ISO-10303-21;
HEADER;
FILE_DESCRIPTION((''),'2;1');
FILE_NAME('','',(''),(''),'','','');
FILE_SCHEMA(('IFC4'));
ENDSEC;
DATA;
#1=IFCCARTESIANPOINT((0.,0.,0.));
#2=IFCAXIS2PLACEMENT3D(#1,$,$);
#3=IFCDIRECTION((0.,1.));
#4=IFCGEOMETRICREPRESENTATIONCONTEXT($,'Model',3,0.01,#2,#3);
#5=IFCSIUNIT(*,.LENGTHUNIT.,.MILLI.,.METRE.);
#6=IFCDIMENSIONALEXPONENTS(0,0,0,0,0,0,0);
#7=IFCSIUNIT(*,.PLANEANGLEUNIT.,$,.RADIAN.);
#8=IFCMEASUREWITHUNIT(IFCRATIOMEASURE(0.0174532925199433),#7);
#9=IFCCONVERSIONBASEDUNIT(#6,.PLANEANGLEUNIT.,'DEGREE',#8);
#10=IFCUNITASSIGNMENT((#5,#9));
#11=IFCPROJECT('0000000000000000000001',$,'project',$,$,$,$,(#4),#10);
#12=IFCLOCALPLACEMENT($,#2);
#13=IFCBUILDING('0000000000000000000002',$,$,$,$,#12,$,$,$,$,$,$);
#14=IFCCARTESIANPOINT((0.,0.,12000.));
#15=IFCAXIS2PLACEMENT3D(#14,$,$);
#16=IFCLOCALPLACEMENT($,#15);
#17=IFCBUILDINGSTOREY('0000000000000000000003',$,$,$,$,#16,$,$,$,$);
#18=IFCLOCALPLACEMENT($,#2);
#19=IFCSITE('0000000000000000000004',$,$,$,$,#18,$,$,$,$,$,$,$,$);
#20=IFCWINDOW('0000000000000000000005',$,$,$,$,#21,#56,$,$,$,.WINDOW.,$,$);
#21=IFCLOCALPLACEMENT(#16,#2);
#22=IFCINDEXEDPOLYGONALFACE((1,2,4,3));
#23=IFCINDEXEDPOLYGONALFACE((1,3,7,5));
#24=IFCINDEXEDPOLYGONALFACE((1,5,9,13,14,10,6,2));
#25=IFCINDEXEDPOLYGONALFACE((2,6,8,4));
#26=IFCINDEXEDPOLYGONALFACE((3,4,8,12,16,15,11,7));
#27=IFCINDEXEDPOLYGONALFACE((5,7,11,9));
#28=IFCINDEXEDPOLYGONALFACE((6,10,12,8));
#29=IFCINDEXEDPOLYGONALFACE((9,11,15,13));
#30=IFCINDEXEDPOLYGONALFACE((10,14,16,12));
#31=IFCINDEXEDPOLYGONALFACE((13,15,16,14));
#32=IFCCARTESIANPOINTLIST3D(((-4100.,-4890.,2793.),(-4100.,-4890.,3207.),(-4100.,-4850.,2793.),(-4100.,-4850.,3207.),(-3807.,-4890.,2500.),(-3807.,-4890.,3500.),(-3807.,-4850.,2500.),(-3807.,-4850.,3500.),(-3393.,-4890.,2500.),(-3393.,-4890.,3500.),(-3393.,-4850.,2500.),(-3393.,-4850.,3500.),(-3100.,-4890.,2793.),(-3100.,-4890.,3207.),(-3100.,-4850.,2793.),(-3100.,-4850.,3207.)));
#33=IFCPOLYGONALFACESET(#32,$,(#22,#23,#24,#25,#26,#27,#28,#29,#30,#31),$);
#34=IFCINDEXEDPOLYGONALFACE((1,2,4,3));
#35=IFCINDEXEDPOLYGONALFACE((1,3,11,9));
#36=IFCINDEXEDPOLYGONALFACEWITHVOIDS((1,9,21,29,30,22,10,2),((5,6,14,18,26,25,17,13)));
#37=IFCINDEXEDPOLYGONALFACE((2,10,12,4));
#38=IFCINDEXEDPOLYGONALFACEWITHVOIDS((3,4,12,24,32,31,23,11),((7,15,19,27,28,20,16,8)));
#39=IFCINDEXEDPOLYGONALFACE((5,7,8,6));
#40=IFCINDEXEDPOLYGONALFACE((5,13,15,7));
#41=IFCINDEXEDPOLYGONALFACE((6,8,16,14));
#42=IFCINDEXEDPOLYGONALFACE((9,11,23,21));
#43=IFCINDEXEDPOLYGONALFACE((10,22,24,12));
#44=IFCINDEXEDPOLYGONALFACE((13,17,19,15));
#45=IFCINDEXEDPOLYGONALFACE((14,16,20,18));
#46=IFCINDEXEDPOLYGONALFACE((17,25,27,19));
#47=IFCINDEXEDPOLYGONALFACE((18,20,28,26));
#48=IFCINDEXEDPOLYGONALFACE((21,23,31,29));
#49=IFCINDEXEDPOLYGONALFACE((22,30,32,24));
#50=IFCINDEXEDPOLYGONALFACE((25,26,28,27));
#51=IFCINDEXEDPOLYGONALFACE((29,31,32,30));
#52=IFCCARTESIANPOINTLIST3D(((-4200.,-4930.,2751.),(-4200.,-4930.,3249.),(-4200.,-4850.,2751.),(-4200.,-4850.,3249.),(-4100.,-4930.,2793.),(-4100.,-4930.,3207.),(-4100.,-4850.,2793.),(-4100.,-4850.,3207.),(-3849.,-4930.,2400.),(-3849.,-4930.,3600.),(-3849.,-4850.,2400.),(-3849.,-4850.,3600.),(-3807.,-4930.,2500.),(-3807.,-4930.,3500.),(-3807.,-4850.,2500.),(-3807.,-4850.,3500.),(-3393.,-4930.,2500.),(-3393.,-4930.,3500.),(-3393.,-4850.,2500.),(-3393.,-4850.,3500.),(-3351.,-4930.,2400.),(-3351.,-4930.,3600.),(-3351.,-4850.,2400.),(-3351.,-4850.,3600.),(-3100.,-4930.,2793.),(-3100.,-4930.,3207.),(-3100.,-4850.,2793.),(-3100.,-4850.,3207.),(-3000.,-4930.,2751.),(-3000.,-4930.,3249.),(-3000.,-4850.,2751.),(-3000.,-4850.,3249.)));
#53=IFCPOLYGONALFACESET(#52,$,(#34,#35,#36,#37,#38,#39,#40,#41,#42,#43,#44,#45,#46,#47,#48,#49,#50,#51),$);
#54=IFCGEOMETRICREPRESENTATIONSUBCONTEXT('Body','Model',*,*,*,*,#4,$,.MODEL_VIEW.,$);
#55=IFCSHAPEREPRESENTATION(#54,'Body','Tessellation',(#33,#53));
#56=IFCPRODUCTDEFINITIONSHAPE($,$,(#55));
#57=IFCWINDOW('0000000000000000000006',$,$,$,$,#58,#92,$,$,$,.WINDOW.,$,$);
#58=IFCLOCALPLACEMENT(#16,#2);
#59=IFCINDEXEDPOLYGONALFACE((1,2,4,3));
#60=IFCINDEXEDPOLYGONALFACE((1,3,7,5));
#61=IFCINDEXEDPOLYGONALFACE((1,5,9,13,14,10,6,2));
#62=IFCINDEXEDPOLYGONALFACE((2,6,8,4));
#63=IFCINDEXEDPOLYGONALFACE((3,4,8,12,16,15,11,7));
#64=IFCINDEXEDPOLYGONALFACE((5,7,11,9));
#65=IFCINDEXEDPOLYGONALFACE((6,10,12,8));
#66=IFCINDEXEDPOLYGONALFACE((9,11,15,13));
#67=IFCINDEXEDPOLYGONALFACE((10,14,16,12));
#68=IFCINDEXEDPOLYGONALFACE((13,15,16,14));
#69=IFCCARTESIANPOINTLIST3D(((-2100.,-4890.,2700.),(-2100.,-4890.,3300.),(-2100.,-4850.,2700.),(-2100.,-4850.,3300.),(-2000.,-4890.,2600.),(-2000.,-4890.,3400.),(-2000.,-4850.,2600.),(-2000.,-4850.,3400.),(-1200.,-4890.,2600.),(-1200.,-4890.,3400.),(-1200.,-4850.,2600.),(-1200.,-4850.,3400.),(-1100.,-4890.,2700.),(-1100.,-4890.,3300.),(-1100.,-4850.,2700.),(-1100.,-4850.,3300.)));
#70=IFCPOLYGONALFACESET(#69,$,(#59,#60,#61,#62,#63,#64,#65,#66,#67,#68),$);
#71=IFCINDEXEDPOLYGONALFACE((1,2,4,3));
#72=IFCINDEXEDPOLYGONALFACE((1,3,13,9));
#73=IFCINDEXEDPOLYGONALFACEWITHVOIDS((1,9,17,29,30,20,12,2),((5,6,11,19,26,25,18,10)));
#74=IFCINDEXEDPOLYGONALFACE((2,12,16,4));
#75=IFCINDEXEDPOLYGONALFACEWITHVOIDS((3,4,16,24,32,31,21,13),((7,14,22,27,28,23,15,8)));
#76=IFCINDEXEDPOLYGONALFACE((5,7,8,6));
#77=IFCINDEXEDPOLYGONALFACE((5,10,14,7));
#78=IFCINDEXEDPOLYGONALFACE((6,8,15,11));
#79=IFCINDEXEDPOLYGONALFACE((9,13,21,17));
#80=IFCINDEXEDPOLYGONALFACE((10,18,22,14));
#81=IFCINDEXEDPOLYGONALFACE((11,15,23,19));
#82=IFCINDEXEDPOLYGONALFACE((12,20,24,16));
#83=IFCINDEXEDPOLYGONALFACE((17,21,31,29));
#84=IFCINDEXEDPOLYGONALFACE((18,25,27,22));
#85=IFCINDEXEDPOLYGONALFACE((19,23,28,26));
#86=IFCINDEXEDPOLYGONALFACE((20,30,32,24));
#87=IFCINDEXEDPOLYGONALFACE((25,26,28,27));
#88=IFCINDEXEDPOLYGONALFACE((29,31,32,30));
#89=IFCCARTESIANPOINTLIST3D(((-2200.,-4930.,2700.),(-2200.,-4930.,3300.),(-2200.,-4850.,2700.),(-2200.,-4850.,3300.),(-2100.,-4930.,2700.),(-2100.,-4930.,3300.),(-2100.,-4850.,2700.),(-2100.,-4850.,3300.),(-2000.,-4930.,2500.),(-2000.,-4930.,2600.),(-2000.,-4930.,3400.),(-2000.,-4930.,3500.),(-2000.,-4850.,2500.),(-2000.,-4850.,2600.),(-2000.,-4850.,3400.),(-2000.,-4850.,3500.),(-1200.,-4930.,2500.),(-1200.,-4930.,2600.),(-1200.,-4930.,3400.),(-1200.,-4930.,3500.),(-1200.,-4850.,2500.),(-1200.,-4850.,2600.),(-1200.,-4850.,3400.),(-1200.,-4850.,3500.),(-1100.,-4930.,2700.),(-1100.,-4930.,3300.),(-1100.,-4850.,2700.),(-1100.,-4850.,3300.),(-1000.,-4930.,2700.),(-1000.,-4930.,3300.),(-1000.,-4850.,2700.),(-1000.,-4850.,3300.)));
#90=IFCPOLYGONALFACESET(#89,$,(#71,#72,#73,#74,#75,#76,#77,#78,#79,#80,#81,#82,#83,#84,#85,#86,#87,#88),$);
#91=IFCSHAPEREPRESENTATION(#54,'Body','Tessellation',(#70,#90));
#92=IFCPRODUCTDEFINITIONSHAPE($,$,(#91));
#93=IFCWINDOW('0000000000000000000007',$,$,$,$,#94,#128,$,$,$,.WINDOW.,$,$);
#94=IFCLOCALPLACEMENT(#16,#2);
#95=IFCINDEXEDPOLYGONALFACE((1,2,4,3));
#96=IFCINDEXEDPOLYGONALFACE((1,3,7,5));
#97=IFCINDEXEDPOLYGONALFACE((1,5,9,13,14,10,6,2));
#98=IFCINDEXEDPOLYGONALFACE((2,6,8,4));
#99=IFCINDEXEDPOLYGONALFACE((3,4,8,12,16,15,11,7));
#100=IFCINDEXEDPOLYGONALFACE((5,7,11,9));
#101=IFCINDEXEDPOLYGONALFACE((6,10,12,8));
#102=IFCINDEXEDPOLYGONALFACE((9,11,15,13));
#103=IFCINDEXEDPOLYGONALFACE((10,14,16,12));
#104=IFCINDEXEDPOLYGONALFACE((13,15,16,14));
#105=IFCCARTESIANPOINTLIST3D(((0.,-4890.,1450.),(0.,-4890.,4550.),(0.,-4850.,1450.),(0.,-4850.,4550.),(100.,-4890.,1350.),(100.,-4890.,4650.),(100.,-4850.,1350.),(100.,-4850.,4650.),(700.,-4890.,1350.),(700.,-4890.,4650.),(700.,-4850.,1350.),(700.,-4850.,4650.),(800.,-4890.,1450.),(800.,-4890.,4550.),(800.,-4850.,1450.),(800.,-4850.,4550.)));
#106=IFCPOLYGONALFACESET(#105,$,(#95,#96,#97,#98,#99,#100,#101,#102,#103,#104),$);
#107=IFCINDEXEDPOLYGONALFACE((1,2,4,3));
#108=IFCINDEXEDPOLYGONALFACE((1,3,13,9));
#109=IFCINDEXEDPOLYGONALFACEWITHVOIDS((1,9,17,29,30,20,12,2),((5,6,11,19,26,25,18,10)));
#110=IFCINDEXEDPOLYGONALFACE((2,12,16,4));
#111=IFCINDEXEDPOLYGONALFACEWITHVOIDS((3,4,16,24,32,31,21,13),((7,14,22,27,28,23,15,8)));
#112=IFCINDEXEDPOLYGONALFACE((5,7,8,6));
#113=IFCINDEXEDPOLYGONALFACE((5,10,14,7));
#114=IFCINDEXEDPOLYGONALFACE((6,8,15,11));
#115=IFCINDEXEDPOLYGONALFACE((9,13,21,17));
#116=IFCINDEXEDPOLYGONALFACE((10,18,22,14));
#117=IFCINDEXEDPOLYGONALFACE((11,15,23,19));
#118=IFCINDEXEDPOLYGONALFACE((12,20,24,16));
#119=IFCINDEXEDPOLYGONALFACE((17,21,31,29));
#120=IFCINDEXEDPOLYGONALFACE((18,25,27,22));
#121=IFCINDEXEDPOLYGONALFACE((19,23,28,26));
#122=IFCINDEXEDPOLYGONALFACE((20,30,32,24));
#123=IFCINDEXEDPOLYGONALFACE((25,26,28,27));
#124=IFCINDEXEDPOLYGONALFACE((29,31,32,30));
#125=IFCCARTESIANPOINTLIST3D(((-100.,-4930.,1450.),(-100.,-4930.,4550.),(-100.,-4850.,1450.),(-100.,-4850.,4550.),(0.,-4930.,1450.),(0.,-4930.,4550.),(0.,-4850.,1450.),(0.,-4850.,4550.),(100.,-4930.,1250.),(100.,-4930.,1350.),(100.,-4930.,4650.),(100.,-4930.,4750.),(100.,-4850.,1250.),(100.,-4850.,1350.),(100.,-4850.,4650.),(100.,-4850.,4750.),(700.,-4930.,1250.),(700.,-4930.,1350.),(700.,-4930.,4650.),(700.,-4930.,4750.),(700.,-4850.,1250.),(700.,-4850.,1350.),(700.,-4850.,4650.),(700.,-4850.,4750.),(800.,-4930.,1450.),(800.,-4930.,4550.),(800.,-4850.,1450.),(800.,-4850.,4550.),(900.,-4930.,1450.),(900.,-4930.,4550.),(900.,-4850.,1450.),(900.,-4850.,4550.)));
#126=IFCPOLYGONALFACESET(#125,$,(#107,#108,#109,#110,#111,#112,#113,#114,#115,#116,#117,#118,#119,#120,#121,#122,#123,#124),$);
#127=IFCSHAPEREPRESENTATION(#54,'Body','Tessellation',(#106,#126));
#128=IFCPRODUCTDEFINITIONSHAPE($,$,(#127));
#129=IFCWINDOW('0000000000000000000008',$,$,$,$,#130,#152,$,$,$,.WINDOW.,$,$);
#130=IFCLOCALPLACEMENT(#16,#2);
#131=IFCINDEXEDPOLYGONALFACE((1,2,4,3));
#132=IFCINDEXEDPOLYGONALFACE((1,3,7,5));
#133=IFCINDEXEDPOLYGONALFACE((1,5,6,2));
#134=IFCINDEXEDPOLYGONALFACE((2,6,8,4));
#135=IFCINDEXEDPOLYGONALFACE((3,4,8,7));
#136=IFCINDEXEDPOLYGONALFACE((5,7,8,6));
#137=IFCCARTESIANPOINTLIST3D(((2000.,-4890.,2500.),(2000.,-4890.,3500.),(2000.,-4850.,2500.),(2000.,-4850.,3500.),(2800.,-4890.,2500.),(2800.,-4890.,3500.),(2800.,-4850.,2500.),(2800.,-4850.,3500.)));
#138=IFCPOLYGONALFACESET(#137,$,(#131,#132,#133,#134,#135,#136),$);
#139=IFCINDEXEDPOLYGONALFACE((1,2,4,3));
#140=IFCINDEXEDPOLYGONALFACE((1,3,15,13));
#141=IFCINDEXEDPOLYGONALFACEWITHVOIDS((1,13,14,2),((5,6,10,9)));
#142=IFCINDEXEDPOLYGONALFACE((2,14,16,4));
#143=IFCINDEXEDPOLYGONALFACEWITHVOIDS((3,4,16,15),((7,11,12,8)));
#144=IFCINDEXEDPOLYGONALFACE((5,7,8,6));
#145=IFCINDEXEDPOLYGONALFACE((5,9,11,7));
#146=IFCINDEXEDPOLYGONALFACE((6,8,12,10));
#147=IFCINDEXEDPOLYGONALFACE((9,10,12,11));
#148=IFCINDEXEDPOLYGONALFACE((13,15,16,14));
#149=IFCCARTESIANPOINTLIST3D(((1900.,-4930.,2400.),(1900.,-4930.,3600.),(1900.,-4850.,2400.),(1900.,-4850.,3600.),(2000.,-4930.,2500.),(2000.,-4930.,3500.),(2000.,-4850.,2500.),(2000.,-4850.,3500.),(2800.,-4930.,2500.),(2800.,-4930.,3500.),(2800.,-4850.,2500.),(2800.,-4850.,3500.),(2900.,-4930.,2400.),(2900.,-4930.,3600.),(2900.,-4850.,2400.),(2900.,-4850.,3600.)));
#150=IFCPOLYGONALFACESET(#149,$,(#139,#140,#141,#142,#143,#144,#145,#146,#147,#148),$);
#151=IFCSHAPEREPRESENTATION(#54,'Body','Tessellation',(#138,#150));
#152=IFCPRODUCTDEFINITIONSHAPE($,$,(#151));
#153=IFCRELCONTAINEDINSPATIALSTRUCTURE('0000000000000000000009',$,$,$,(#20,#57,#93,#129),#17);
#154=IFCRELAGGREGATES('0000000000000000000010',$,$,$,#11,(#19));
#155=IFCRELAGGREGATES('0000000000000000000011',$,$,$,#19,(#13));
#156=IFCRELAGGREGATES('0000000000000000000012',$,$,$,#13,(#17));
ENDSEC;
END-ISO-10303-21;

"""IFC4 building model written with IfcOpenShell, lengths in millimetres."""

from ifc_helpers import new_model, entity, si_unit, converted_unit, direction, frame, origin, place, context, subcontext, project, spatial, element, save


model = new_model("IFC4")

# Units and contexts
model_context = context("Model", 3, precision=0.01, world=origin(), true_north=direction((0.0, 1.0)))
body_context = subcontext(model_context, "Body", "Model", "MODEL_VIEW")
ifc_project = project(units=[si_unit("LENGTHUNIT", "METRE", prefix="MILLI"), converted_unit("PLANEANGLEUNIT", "DEGREE", entity("IfcRatioMeasure", 0.0174532925199433), si_unit("PLANEANGLEUNIT", "RADIAN"), dimensions=[0, 0, 0, 0, 0, 0, 0])], contexts=[model_context])

# Site, building, storey
site_placement = place(None, origin())
site = spatial("IfcSite", under=ifc_project, at=site_placement)
building_placement = place(None, origin())
building = spatial("IfcBuilding", under=site, at=building_placement)
storey_placement = place(None, frame((0.0, 0.0, 12000.0)))
storey = spatial("IfcBuildingStorey", under=building, at=storey_placement)

# Shared definitions
cartesian_point_1 = entity("IfcCartesianPoint", [-500.0, -207.0])
shared_polyline_1 = entity("IfcPolyline", [cartesian_point_1, entity("IfcCartesianPoint", [-500.0, 207.0]), entity("IfcCartesianPoint", [-207.0, 500.0]), entity("IfcCartesianPoint", [207.0, 500.0]), entity("IfcCartesianPoint", [500.0, 207.0]), entity("IfcCartesianPoint", [500.0, -207.0]), entity("IfcCartesianPoint", [207.0, -500.0]), entity("IfcCartesianPoint", [-207.0, -500.0]), cartesian_point_1])
cartesian_point_2 = entity("IfcCartesianPoint", [-500.0, -300.0])
shared_polyline_2 = entity("IfcPolyline", [cartesian_point_2, entity("IfcCartesianPoint", [-500.0, 300.0]), entity("IfcCartesianPoint", [-400.0, 400.0]), entity("IfcCartesianPoint", [400.0, 400.0]), entity("IfcCartesianPoint", [500.0, 300.0]), entity("IfcCartesianPoint", [500.0, -300.0]), entity("IfcCartesianPoint", [400.0, -400.0]), entity("IfcCartesianPoint", [-400.0, -400.0]), cartesian_point_2])
cartesian_point_3 = entity("IfcCartesianPoint", [-400.0, -1550.0])
shared_polyline_3 = entity("IfcPolyline", [cartesian_point_3, entity("IfcCartesianPoint", [-400.0, 1550.0]), entity("IfcCartesianPoint", [-300.0, 1650.0]), entity("IfcCartesianPoint", [300.0, 1650.0]), entity("IfcCartesianPoint", [400.0, 1550.0]), entity("IfcCartesianPoint", [400.0, -1550.0]), entity("IfcCartesianPoint", [300.0, -1650.0]), entity("IfcCartesianPoint", [-300.0, -1650.0]), cartesian_point_3])
cartesian_point_4 = entity("IfcCartesianPoint", [-400.0, -500.0])
shared_polyline_4 = entity("IfcPolyline", [cartesian_point_4, entity("IfcCartesianPoint", [-400.0, 500.0]), entity("IfcCartesianPoint", [-400.0, 500.0]), entity("IfcCartesianPoint", [400.0, 500.0]), entity("IfcCartesianPoint", [400.0, 500.0]), entity("IfcCartesianPoint", [400.0, -500.0]), entity("IfcCartesianPoint", [400.0, -500.0]), entity("IfcCartesianPoint", [-400.0, -500.0]), cartesian_point_4])

# Shared definitions
wall_1_placement = place(storey_placement, frame((-100.0, -4900.0, 0.0), z_axis=(0.0, 0.0, 1.0), x_axis=(1.0, 0.0, 0.0)))
window_1_placement = place(wall_1_placement, frame((-3500.0, 50.0, 3000.0)))
window_2_placement = place(wall_1_placement, frame((-1500.0, 50.0, 3000.0)))
window_3_placement = place(wall_1_placement, frame((500.0, 50.0, 3000.0)))
window_4_placement = place(wall_1_placement, frame((2500.0, 50.0, 3000.0)))

# Windows
cartesian_point_5 = entity("IfcCartesianPoint", [-600.0, -249.0])
element("IfcWindow", 1, at=window_1_placement, inside=storey, PredefinedType="WINDOW", context=body_context, shape_type="SweptSolid", body=[
    entity("IfcExtrudedAreaSolid", entity("IfcArbitraryClosedProfileDef", "AREA", None, shared_polyline_1), entity("IfcAxis2Placement3D", entity("IfcCartesianPoint", [0.0, 0.0, 0.0]), entity("IfcDirection", [0.0, -1.0, 0.0]), entity("IfcDirection", [1.0, 0.0, 0.0])), entity("IfcDirection", [0.0, 0.0, 1.0]), 40.0),
    entity("IfcExtrudedAreaSolid", entity("IfcArbitraryProfileDefWithVoids", "AREA", None, entity("IfcPolyline", [cartesian_point_5, entity("IfcCartesianPoint", [-600.0, 249.0]), entity("IfcCartesianPoint", [-249.0, 600.0]), entity("IfcCartesianPoint", [249.0, 600.0]), entity("IfcCartesianPoint", [600.0, 249.0]), entity("IfcCartesianPoint", [600.0, -249.0]), entity("IfcCartesianPoint", [249.0, -600.0]), entity("IfcCartesianPoint", [-249.0, -600.0]), cartesian_point_5]), [shared_polyline_1]), entity("IfcAxis2Placement3D", entity("IfcCartesianPoint", [0.0, 0.0, 0.0]), entity("IfcDirection", [0.0, -1.0, 0.0]), entity("IfcDirection", [1.0, 0.0, 0.0])), entity("IfcDirection", [0.0, 0.0, 1.0]), 80.0),
])
cartesian_point_6 = entity("IfcCartesianPoint", [-600.0, -300.0])
element("IfcWindow", 2, at=window_2_placement, inside=storey, PredefinedType="WINDOW", context=body_context, shape_type="SweptSolid", body=[
    entity("IfcExtrudedAreaSolid", entity("IfcArbitraryClosedProfileDef", "AREA", None, shared_polyline_2), entity("IfcAxis2Placement3D", entity("IfcCartesianPoint", [0.0, 0.0, 0.0]), entity("IfcDirection", [0.0, -1.0, 0.0]), entity("IfcDirection", [1.0, 0.0, 0.0])), entity("IfcDirection", [0.0, 0.0, 1.0]), 40.0),
    entity("IfcExtrudedAreaSolid", entity("IfcArbitraryProfileDefWithVoids", "AREA", None, entity("IfcPolyline", [cartesian_point_6, entity("IfcCartesianPoint", [-600.0, 300.0]), entity("IfcCartesianPoint", [-400.0, 500.0]), entity("IfcCartesianPoint", [400.0, 500.0]), entity("IfcCartesianPoint", [600.0, 300.0]), entity("IfcCartesianPoint", [600.0, -300.0]), entity("IfcCartesianPoint", [400.0, -500.0]), entity("IfcCartesianPoint", [-400.0, -500.0]), cartesian_point_6]), [shared_polyline_2]), entity("IfcAxis2Placement3D", entity("IfcCartesianPoint", [0.0, 0.0, 0.0]), entity("IfcDirection", [0.0, -1.0, 0.0]), entity("IfcDirection", [1.0, 0.0, 0.0])), entity("IfcDirection", [0.0, 0.0, 1.0]), 80.0),
])
cartesian_point_7 = entity("IfcCartesianPoint", [-500.0, -1550.0])
element("IfcWindow", 3, at=window_3_placement, inside=storey, PredefinedType="WINDOW", context=body_context, shape_type="SweptSolid", body=[
    entity("IfcExtrudedAreaSolid", entity("IfcArbitraryClosedProfileDef", "AREA", None, shared_polyline_3), entity("IfcAxis2Placement3D", entity("IfcCartesianPoint", [0.0, 0.0, 0.0]), entity("IfcDirection", [0.0, -1.0, 0.0]), entity("IfcDirection", [1.0, 0.0, 0.0])), entity("IfcDirection", [0.0, 0.0, 1.0]), 40.0),
    entity("IfcExtrudedAreaSolid", entity("IfcArbitraryProfileDefWithVoids", "AREA", None, entity("IfcPolyline", [cartesian_point_7, entity("IfcCartesianPoint", [-500.0, 1550.0]), entity("IfcCartesianPoint", [-300.0, 1750.0]), entity("IfcCartesianPoint", [300.0, 1750.0]), entity("IfcCartesianPoint", [500.0, 1550.0]), entity("IfcCartesianPoint", [500.0, -1550.0]), entity("IfcCartesianPoint", [300.0, -1750.0]), entity("IfcCartesianPoint", [-300.0, -1750.0]), cartesian_point_7]), [shared_polyline_3]), entity("IfcAxis2Placement3D", entity("IfcCartesianPoint", [0.0, 0.0, 0.0]), entity("IfcDirection", [0.0, -1.0, 0.0]), entity("IfcDirection", [1.0, 0.0, 0.0])), entity("IfcDirection", [0.0, 0.0, 1.0]), 80.0),
])
cartesian_point_8 = entity("IfcCartesianPoint", [-500.0, -600.0])
element("IfcWindow", 4, at=window_4_placement, inside=storey, PredefinedType="WINDOW", context=body_context, shape_type="SweptSolid", body=[
    entity("IfcExtrudedAreaSolid", entity("IfcArbitraryClosedProfileDef", "AREA", None, shared_polyline_4), entity("IfcAxis2Placement3D", entity("IfcCartesianPoint", [0.0, 0.0, 0.0]), entity("IfcDirection", [0.0, -1.0, 0.0]), entity("IfcDirection", [1.0, 0.0, 0.0])), entity("IfcDirection", [0.0, 0.0, 1.0]), 40.0),
    entity("IfcExtrudedAreaSolid", entity("IfcArbitraryProfileDefWithVoids", "AREA", None, entity("IfcPolyline", [cartesian_point_8, entity("IfcCartesianPoint", [-500.0, 600.0]), entity("IfcCartesianPoint", [-500.0, 600.0]), entity("IfcCartesianPoint", [500.0, 600.0]), entity("IfcCartesianPoint", [500.0, 600.0]), entity("IfcCartesianPoint", [500.0, -600.0]), entity("IfcCartesianPoint", [500.0, -600.0]), entity("IfcCartesianPoint", [-500.0, -600.0]), cartesian_point_8]), [shared_polyline_4]), entity("IfcAxis2Placement3D", entity("IfcCartesianPoint", [0.0, 0.0, 0.0]), entity("IfcDirection", [0.0, -1.0, 0.0]), entity("IfcDirection", [1.0, 0.0, 0.0])), entity("IfcDirection", [0.0, 0.0, 1.0]), 80.0),
])

save(model, "model.ifc")
